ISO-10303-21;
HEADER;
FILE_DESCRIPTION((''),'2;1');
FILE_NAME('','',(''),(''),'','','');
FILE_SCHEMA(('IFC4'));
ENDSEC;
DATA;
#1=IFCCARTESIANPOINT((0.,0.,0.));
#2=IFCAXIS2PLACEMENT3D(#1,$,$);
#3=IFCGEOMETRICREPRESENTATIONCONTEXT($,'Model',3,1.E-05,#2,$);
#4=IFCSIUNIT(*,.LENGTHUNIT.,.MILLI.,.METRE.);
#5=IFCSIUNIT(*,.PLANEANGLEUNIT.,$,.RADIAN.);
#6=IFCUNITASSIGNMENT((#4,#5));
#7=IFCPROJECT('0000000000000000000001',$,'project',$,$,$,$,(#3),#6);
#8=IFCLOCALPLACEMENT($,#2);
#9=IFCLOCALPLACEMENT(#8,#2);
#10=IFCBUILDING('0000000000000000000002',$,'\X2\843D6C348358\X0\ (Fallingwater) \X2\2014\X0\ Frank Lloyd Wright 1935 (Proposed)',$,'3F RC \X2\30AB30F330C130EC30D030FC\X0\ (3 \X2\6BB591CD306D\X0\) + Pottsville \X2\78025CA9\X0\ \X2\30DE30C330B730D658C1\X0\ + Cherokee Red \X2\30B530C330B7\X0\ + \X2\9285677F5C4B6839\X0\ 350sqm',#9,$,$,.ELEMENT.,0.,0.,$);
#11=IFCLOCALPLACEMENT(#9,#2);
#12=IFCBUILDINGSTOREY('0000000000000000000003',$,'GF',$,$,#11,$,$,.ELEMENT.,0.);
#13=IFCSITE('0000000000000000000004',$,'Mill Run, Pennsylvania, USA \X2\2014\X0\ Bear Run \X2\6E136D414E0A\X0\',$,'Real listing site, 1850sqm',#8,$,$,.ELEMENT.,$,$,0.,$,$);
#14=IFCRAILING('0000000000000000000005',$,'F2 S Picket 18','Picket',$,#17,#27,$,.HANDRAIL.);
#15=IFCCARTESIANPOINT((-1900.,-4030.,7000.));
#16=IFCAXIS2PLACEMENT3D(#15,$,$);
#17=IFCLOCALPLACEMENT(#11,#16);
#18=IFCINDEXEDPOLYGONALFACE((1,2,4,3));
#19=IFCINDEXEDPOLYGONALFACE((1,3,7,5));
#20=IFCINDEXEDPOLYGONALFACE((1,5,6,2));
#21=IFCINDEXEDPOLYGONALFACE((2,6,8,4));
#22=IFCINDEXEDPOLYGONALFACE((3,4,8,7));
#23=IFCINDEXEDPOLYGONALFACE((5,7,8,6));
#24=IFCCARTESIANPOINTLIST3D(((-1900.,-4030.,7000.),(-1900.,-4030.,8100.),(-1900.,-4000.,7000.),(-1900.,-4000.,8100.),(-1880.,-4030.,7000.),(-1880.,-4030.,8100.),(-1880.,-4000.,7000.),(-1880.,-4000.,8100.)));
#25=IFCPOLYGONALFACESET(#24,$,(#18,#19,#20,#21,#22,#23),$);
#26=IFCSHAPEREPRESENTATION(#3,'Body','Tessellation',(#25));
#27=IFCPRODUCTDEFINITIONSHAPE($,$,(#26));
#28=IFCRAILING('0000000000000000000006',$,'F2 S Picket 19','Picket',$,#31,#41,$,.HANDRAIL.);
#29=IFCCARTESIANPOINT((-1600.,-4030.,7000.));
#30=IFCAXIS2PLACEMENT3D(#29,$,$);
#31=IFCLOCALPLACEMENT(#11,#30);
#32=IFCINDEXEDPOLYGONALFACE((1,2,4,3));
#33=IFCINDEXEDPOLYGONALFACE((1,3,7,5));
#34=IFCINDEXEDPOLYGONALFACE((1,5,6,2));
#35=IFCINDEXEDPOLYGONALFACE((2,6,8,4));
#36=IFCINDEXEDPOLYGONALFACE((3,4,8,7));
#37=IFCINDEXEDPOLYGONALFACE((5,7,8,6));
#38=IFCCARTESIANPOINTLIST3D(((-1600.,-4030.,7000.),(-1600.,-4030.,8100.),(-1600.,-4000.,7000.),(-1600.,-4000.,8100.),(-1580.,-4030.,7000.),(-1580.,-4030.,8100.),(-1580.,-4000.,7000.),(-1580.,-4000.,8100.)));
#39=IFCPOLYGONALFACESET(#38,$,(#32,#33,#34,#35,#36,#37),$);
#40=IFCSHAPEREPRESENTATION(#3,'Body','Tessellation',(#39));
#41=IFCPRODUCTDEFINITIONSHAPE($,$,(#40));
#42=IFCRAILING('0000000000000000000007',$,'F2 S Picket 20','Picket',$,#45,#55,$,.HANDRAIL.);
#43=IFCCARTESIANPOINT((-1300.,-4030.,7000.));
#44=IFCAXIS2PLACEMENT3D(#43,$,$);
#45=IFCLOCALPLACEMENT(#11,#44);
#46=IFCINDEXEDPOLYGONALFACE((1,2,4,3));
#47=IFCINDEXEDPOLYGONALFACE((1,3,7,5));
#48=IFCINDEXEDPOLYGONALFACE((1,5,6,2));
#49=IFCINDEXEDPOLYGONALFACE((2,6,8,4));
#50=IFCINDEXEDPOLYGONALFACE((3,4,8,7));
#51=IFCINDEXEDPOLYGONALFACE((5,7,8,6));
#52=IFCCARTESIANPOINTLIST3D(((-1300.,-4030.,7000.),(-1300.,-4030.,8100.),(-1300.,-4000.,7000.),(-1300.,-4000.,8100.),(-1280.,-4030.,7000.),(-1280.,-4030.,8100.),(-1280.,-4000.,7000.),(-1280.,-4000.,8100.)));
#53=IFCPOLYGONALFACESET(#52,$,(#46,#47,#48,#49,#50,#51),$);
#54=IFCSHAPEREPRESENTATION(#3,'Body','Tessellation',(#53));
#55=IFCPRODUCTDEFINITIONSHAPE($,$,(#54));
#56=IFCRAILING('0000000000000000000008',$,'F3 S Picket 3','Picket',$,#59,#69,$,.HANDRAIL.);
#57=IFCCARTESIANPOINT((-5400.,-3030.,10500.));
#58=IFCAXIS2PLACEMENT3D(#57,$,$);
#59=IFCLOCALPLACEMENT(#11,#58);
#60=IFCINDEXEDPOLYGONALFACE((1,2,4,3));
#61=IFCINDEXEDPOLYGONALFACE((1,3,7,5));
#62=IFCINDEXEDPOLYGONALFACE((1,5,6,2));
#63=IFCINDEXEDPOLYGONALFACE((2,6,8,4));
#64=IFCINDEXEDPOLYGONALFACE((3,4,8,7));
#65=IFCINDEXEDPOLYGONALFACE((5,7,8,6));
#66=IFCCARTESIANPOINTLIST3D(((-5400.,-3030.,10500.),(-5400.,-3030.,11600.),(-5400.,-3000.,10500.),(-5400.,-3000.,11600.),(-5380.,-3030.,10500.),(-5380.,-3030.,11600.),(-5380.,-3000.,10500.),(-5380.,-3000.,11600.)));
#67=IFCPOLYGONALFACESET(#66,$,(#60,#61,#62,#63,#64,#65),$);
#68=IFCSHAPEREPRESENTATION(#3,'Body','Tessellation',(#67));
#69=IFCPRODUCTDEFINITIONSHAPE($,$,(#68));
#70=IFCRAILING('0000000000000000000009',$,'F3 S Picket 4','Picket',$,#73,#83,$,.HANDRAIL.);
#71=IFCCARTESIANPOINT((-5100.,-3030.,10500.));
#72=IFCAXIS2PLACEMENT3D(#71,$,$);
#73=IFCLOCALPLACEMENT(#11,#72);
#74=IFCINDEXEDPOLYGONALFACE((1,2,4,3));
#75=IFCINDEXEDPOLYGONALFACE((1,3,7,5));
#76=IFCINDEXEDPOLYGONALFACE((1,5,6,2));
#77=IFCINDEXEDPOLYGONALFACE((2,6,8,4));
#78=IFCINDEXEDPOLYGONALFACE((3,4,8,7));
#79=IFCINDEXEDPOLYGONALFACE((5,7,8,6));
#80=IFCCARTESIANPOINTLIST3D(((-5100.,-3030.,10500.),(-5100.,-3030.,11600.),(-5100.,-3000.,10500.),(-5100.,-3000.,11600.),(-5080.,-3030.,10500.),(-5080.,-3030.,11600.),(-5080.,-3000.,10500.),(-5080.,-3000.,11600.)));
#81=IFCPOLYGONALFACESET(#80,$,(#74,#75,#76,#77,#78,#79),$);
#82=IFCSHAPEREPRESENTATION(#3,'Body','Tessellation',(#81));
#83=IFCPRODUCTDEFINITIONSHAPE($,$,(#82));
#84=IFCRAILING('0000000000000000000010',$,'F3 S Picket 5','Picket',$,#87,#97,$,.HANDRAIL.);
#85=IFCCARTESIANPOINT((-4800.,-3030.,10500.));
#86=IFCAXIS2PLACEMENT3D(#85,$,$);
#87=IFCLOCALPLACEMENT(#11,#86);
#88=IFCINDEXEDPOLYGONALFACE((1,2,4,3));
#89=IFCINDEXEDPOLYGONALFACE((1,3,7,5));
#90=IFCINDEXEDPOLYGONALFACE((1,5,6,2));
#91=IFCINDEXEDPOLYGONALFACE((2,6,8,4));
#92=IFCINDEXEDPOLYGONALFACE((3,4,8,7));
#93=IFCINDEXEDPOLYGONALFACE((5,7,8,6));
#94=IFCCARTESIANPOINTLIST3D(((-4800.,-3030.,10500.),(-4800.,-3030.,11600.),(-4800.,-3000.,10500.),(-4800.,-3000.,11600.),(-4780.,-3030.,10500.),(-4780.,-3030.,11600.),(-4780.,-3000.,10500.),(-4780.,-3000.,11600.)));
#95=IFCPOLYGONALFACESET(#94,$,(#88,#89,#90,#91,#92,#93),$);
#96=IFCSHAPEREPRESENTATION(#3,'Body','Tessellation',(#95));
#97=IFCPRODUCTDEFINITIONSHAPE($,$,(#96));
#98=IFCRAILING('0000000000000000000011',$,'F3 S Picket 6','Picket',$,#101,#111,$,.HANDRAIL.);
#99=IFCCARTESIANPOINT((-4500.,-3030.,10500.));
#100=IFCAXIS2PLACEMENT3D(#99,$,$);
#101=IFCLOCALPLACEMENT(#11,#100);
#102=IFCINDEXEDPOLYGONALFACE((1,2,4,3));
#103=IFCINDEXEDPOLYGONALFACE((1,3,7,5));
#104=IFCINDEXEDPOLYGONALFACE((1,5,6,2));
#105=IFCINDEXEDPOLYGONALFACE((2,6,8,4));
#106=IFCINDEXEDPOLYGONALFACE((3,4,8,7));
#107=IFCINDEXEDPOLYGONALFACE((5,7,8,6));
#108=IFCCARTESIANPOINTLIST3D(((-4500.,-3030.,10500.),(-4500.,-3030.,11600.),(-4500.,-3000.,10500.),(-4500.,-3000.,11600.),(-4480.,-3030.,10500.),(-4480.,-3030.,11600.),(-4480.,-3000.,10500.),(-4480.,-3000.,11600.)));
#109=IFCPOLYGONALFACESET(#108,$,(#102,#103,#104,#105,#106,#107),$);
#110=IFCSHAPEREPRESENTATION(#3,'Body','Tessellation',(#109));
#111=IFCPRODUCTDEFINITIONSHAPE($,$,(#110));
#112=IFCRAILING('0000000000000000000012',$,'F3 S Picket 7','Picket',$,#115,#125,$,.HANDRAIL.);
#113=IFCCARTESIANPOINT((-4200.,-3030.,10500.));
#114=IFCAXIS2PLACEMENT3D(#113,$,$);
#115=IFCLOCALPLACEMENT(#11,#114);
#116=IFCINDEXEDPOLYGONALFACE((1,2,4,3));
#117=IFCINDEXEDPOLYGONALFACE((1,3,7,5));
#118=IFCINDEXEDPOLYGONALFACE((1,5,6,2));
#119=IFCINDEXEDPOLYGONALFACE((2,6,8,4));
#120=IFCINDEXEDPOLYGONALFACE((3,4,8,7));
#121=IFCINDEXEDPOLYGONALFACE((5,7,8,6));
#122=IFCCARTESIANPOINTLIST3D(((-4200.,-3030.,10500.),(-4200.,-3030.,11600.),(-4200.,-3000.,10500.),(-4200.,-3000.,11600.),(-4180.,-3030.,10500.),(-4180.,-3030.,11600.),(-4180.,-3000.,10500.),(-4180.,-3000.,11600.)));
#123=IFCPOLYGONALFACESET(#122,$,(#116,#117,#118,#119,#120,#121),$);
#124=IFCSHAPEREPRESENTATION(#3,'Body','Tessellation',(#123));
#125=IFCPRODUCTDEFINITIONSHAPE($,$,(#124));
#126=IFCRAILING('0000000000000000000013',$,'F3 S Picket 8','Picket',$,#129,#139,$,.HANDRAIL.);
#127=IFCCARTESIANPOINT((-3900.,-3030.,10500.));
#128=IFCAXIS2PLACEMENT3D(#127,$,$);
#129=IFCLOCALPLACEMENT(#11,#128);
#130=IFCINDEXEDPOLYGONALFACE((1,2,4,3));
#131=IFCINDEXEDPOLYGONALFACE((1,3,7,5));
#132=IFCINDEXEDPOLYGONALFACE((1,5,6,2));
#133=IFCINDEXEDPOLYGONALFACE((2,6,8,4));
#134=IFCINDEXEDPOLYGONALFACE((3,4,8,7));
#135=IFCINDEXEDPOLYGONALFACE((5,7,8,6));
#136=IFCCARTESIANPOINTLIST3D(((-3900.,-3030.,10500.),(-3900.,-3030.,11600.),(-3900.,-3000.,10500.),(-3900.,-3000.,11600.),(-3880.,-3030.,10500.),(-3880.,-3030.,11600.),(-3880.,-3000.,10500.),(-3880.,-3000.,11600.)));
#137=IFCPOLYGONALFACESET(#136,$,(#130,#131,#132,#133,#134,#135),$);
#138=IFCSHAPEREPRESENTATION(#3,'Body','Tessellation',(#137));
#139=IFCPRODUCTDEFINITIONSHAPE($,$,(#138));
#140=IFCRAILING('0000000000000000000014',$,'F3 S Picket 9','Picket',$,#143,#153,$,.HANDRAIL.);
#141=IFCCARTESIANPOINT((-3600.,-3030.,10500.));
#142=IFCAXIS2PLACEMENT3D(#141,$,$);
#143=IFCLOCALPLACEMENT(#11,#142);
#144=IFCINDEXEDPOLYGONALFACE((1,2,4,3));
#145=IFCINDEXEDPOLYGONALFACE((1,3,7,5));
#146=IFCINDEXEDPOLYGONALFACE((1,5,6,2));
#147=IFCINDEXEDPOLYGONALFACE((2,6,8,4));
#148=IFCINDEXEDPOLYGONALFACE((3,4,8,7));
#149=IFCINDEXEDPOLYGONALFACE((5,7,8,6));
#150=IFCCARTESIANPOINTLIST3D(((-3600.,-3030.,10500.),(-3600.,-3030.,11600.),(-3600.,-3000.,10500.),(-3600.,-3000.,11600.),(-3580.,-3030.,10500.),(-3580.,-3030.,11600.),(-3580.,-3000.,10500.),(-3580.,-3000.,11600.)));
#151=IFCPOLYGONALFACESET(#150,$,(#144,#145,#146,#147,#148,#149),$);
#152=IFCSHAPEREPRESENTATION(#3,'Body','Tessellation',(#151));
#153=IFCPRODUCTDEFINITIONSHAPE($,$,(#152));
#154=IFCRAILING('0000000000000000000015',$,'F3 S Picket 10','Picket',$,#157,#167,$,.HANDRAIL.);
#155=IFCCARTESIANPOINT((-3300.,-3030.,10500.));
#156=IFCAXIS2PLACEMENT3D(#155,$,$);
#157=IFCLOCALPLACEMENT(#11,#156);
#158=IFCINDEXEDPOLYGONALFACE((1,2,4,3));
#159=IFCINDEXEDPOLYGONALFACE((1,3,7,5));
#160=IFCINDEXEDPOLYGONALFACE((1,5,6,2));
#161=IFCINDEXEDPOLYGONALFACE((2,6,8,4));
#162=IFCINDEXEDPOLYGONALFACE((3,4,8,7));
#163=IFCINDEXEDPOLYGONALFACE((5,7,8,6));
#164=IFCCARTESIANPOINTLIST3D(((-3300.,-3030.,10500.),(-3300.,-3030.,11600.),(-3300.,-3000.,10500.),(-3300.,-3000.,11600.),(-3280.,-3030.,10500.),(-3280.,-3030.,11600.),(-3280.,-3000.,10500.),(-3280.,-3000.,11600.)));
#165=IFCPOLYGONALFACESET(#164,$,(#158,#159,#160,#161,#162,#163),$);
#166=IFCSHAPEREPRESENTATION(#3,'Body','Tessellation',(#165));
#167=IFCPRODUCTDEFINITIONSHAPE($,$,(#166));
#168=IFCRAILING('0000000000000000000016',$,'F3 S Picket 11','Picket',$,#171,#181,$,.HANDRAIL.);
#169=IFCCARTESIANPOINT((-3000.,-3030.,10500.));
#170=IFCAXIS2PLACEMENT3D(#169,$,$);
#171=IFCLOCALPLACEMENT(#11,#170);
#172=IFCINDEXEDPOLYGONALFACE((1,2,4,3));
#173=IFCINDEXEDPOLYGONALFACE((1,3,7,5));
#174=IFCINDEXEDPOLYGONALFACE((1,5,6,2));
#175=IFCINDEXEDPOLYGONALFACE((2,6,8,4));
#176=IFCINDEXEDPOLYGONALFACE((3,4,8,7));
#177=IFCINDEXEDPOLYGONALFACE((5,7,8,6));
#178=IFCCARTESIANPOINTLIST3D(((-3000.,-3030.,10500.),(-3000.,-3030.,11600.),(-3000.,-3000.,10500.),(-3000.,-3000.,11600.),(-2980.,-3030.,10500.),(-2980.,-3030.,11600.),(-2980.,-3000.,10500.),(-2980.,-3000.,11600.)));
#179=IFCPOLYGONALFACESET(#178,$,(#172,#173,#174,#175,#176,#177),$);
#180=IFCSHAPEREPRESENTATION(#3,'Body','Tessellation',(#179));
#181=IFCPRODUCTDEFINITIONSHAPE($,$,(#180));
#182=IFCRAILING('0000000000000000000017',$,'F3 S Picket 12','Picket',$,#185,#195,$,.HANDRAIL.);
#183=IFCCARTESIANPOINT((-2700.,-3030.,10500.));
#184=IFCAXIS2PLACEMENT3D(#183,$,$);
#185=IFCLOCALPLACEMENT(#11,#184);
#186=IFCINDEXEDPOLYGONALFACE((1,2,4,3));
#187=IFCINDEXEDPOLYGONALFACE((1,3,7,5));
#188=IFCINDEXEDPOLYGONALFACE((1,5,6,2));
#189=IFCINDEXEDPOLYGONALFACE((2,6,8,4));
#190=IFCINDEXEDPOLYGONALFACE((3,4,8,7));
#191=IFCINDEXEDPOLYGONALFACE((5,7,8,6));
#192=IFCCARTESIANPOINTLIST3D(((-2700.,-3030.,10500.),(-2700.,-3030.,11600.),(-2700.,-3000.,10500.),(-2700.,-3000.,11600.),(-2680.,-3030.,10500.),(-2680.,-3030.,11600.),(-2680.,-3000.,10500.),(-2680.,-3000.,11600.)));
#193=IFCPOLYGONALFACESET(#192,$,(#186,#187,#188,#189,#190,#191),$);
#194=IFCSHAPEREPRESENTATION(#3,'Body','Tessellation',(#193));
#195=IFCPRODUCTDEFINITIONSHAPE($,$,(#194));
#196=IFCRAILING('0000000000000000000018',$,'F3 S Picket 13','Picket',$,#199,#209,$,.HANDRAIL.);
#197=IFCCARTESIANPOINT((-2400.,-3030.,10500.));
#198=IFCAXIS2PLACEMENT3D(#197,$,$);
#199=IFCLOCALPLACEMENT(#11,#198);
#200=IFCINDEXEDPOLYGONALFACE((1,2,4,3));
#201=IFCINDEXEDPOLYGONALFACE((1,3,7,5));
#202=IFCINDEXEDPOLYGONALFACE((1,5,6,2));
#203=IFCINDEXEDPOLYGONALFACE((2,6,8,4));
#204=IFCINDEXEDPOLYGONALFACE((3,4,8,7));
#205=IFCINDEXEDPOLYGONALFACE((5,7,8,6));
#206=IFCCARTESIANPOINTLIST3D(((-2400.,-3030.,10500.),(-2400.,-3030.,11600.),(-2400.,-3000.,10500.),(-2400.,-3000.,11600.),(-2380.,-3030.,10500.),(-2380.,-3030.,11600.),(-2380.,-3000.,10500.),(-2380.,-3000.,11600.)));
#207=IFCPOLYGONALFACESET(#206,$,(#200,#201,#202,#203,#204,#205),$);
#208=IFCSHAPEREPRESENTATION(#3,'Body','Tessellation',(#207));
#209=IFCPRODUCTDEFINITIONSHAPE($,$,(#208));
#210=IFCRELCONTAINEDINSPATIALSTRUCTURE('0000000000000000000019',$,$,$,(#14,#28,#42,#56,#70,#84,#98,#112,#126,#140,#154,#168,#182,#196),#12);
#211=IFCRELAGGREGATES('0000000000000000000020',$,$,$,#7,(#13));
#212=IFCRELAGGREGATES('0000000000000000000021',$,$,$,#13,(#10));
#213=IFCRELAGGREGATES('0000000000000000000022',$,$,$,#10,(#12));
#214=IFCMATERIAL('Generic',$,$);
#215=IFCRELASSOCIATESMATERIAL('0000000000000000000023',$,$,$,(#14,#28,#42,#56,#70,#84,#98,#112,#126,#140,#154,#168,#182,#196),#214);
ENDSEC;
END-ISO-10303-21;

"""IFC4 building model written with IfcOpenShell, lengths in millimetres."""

from ifc_helpers import new_model, si_unit, frame, frame_2d, origin, place, context, project, spatial, rectangle, extrude, material, element, save


model = new_model("IFC4")

# Units and contexts
model_context = context("Model", 3, precision=1e-05, world=origin())
ifc_project = project(units=[si_unit("LENGTHUNIT", "METRE", prefix="MILLI"), si_unit("PLANEANGLEUNIT", "RADIAN")], contexts=[model_context])

# Site, building, storey
site_placement = place(None, origin())
site = spatial("IfcSite", under=ifc_project, at=site_placement, Name="Mill Run, Pennsylvania, USA — Bear Run 渓流上", ObjectType="Real listing site, 1850sqm", CompositionType="ELEMENT", RefElevation=0.0)
building_placement = place(site_placement, origin())
building = spatial("IfcBuilding", under=site, at=building_placement, Name="落水荘 (Fallingwater) — Frank Lloyd Wright 1935 (Proposed)", ObjectType="3F RC カンチレバー (3 段重ね) + Pottsville 砂岩 マッシブ壁 + Cherokee Red サッシ + 銅板屋根 350sqm", CompositionType="ELEMENT", ElevationOfRefHeight=0.0, ElevationOfTerrain=0.0)
storey_placement = place(building_placement, origin())
storey = spatial("IfcBuildingStorey", under=building, at=storey_placement, Name="GF", CompositionType="ELEMENT", Elevation=0.0)

# Railings
ifc_material_1 = material(Name="Generic")
railing_1_placement = place(storey_placement, frame((-1900.0, -4030.0, 7000.0)))
element("IfcRailing", 1, at=railing_1_placement, inside=storey, material=ifc_material_1, Name="F2 S Picket 18", Description="Picket", PredefinedType="HANDRAIL", context=model_context, shape_type="SweptSolid", body=[
    extrude(rectangle(XDim=20.0, YDim=30.0, at=frame_2d((10.0, 15.0))), frame((-1900.0, -4030.0, 7000.0)), (0.0, 0.0, 1.0), 1100.0),
])
railing_2_placement = place(storey_placement, frame((-1600.0, -4030.0, 7000.0)))
element("IfcRailing", 2, at=railing_2_placement, inside=storey, material=ifc_material_1, Name="F2 S Picket 19", Description="Picket", PredefinedType="HANDRAIL", context=model_context, shape_type="SweptSolid", body=[
    extrude(rectangle(XDim=20.0, YDim=30.0, at=frame_2d((10.0, 15.0))), frame((-1600.0, -4030.0, 7000.0)), (0.0, 0.0, 1.0), 1100.0),
])
railing_3_placement = place(storey_placement, frame((-1300.0, -4030.0, 7000.0)))
element("IfcRailing", 3, at=railing_3_placement, inside=storey, material=ifc_material_1, Name="F2 S Picket 20", Description="Picket", PredefinedType="HANDRAIL", context=model_context, shape_type="SweptSolid", body=[
    extrude(rectangle(XDim=20.0, YDim=30.0, at=frame_2d((10.0, 15.0))), frame((-1300.0, -4030.0, 7000.0)), (0.0, 0.0, 1.0), 1100.0),
])
railing_4_placement = place(storey_placement, frame((-5400.0, -3030.0, 10500.0)))
element("IfcRailing", 4, at=railing_4_placement, inside=storey, material=ifc_material_1, Name="F3 S Picket 3", Description="Picket", PredefinedType="HANDRAIL", context=model_context, shape_type="SweptSolid", body=[
    extrude(rectangle(XDim=20.0, YDim=30.0, at=frame_2d((10.0, 15.0))), frame((-5400.0, -3030.0, 10500.0)), (0.0, 0.0, 1.0), 1100.0),
])
railing_5_placement = place(storey_placement, frame((-5100.0, -3030.0, 10500.0)))
element("IfcRailing", 5, at=railing_5_placement, inside=storey, material=ifc_material_1, Name="F3 S Picket 4", Description="Picket", PredefinedType="HANDRAIL", context=model_context, shape_type="SweptSolid", body=[
    extrude(rectangle(XDim=20.0, YDim=30.0, at=frame_2d((10.0, 15.0))), frame((-5100.0, -3030.0, 10500.0)), (0.0, 0.0, 1.0), 1100.0),
])
railing_6_placement = place(storey_placement, frame((-4800.0, -3030.0, 10500.0)))
element("IfcRailing", 6, at=railing_6_placement, inside=storey, material=ifc_material_1, Name="F3 S Picket 5", Description="Picket", PredefinedType="HANDRAIL", context=model_context, shape_type="SweptSolid", body=[
    extrude(rectangle(XDim=20.0, YDim=30.0, at=frame_2d((10.0, 15.0))), frame((-4800.0, -3030.0, 10500.0)), (0.0, 0.0, 1.0), 1100.0),
])
railing_7_placement = place(storey_placement, frame((-4500.0, -3030.0, 10500.0)))
element("IfcRailing", 7, at=railing_7_placement, inside=storey, material=ifc_material_1, Name="F3 S Picket 6", Description="Picket", PredefinedType="HANDRAIL", context=model_context, shape_type="SweptSolid", body=[
    extrude(rectangle(XDim=20.0, YDim=30.0, at=frame_2d((10.0, 15.0))), frame((-4500.0, -3030.0, 10500.0)), (0.0, 0.0, 1.0), 1100.0),
])
railing_8_placement = place(storey_placement, frame((-4200.0, -3030.0, 10500.0)))
element("IfcRailing", 8, at=railing_8_placement, inside=storey, material=ifc_material_1, Name="F3 S Picket 7", Description="Picket", PredefinedType="HANDRAIL", context=model_context, shape_type="SweptSolid", body=[
    extrude(rectangle(XDim=20.0, YDim=30.0, at=frame_2d((10.0, 15.0))), frame((-4200.0, -3030.0, 10500.0)), (0.0, 0.0, 1.0), 1100.0),
])
railing_9_placement = place(storey_placement, frame((-3900.0, -3030.0, 10500.0)))
element("IfcRailing", 9, at=railing_9_placement, inside=storey, material=ifc_material_1, Name="F3 S Picket 8", Description="Picket", PredefinedType="HANDRAIL", context=model_context, shape_type="SweptSolid", body=[
    extrude(rectangle(XDim=20.0, YDim=30.0, at=frame_2d((10.0, 15.0))), frame((-3900.0, -3030.0, 10500.0)), (0.0, 0.0, 1.0), 1100.0),
])
railing_10_placement = place(storey_placement, frame((-3600.0, -3030.0, 10500.0)))
element("IfcRailing", 10, at=railing_10_placement, inside=storey, material=ifc_material_1, Name="F3 S Picket 9", Description="Picket", PredefinedType="HANDRAIL", context=model_context, shape_type="SweptSolid", body=[
    extrude(rectangle(XDim=20.0, YDim=30.0, at=frame_2d((10.0, 15.0))), frame((-3600.0, -3030.0, 10500.0)), (0.0, 0.0, 1.0), 1100.0),
])
railing_11_placement = place(storey_placement, frame((-3300.0, -3030.0, 10500.0)))
element("IfcRailing", 11, at=railing_11_placement, inside=storey, material=ifc_material_1, Name="F3 S Picket 10", Description="Picket", PredefinedType="HANDRAIL", context=model_context, shape_type="SweptSolid", body=[
    extrude(rectangle(XDim=20.0, YDim=30.0, at=frame_2d((10.0, 15.0))), frame((-3300.0, -3030.0, 10500.0)), (0.0, 0.0, 1.0), 1100.0),
])
railing_12_placement = place(storey_placement, frame((-3000.0, -3030.0, 10500.0)))
element("IfcRailing", 12, at=railing_12_placement, inside=storey, material=ifc_material_1, Name="F3 S Picket 11", Description="Picket", PredefinedType="HANDRAIL", context=model_context, shape_type="SweptSolid", body=[
    extrude(rectangle(XDim=20.0, YDim=30.0, at=frame_2d((10.0, 15.0))), frame((-3000.0, -3030.0, 10500.0)), (0.0, 0.0, 1.0), 1100.0),
])
railing_13_placement = place(storey_placement, frame((-2700.0, -3030.0, 10500.0)))
element("IfcRailing", 13, at=railing_13_placement, inside=storey, material=ifc_material_1, Name="F3 S Picket 12", Description="Picket", PredefinedType="HANDRAIL", context=model_context, shape_type="SweptSolid", body=[
    extrude(rectangle(XDim=20.0, YDim=30.0, at=frame_2d((10.0, 15.0))), frame((-2700.0, -3030.0, 10500.0)), (0.0, 0.0, 1.0), 1100.0),
])
railing_14_placement = place(storey_placement, frame((-2400.0, -3030.0, 10500.0)))
element("IfcRailing", 14, at=railing_14_placement, inside=storey, material=ifc_material_1, Name="F3 S Picket 13", Description="Picket", PredefinedType="HANDRAIL", context=model_context, shape_type="SweptSolid", body=[
    extrude(rectangle(XDim=20.0, YDim=30.0, at=frame_2d((10.0, 15.0))), frame((-2400.0, -3030.0, 10500.0)), (0.0, 0.0, 1.0), 1100.0),
])

save(model, "model.ifc")
